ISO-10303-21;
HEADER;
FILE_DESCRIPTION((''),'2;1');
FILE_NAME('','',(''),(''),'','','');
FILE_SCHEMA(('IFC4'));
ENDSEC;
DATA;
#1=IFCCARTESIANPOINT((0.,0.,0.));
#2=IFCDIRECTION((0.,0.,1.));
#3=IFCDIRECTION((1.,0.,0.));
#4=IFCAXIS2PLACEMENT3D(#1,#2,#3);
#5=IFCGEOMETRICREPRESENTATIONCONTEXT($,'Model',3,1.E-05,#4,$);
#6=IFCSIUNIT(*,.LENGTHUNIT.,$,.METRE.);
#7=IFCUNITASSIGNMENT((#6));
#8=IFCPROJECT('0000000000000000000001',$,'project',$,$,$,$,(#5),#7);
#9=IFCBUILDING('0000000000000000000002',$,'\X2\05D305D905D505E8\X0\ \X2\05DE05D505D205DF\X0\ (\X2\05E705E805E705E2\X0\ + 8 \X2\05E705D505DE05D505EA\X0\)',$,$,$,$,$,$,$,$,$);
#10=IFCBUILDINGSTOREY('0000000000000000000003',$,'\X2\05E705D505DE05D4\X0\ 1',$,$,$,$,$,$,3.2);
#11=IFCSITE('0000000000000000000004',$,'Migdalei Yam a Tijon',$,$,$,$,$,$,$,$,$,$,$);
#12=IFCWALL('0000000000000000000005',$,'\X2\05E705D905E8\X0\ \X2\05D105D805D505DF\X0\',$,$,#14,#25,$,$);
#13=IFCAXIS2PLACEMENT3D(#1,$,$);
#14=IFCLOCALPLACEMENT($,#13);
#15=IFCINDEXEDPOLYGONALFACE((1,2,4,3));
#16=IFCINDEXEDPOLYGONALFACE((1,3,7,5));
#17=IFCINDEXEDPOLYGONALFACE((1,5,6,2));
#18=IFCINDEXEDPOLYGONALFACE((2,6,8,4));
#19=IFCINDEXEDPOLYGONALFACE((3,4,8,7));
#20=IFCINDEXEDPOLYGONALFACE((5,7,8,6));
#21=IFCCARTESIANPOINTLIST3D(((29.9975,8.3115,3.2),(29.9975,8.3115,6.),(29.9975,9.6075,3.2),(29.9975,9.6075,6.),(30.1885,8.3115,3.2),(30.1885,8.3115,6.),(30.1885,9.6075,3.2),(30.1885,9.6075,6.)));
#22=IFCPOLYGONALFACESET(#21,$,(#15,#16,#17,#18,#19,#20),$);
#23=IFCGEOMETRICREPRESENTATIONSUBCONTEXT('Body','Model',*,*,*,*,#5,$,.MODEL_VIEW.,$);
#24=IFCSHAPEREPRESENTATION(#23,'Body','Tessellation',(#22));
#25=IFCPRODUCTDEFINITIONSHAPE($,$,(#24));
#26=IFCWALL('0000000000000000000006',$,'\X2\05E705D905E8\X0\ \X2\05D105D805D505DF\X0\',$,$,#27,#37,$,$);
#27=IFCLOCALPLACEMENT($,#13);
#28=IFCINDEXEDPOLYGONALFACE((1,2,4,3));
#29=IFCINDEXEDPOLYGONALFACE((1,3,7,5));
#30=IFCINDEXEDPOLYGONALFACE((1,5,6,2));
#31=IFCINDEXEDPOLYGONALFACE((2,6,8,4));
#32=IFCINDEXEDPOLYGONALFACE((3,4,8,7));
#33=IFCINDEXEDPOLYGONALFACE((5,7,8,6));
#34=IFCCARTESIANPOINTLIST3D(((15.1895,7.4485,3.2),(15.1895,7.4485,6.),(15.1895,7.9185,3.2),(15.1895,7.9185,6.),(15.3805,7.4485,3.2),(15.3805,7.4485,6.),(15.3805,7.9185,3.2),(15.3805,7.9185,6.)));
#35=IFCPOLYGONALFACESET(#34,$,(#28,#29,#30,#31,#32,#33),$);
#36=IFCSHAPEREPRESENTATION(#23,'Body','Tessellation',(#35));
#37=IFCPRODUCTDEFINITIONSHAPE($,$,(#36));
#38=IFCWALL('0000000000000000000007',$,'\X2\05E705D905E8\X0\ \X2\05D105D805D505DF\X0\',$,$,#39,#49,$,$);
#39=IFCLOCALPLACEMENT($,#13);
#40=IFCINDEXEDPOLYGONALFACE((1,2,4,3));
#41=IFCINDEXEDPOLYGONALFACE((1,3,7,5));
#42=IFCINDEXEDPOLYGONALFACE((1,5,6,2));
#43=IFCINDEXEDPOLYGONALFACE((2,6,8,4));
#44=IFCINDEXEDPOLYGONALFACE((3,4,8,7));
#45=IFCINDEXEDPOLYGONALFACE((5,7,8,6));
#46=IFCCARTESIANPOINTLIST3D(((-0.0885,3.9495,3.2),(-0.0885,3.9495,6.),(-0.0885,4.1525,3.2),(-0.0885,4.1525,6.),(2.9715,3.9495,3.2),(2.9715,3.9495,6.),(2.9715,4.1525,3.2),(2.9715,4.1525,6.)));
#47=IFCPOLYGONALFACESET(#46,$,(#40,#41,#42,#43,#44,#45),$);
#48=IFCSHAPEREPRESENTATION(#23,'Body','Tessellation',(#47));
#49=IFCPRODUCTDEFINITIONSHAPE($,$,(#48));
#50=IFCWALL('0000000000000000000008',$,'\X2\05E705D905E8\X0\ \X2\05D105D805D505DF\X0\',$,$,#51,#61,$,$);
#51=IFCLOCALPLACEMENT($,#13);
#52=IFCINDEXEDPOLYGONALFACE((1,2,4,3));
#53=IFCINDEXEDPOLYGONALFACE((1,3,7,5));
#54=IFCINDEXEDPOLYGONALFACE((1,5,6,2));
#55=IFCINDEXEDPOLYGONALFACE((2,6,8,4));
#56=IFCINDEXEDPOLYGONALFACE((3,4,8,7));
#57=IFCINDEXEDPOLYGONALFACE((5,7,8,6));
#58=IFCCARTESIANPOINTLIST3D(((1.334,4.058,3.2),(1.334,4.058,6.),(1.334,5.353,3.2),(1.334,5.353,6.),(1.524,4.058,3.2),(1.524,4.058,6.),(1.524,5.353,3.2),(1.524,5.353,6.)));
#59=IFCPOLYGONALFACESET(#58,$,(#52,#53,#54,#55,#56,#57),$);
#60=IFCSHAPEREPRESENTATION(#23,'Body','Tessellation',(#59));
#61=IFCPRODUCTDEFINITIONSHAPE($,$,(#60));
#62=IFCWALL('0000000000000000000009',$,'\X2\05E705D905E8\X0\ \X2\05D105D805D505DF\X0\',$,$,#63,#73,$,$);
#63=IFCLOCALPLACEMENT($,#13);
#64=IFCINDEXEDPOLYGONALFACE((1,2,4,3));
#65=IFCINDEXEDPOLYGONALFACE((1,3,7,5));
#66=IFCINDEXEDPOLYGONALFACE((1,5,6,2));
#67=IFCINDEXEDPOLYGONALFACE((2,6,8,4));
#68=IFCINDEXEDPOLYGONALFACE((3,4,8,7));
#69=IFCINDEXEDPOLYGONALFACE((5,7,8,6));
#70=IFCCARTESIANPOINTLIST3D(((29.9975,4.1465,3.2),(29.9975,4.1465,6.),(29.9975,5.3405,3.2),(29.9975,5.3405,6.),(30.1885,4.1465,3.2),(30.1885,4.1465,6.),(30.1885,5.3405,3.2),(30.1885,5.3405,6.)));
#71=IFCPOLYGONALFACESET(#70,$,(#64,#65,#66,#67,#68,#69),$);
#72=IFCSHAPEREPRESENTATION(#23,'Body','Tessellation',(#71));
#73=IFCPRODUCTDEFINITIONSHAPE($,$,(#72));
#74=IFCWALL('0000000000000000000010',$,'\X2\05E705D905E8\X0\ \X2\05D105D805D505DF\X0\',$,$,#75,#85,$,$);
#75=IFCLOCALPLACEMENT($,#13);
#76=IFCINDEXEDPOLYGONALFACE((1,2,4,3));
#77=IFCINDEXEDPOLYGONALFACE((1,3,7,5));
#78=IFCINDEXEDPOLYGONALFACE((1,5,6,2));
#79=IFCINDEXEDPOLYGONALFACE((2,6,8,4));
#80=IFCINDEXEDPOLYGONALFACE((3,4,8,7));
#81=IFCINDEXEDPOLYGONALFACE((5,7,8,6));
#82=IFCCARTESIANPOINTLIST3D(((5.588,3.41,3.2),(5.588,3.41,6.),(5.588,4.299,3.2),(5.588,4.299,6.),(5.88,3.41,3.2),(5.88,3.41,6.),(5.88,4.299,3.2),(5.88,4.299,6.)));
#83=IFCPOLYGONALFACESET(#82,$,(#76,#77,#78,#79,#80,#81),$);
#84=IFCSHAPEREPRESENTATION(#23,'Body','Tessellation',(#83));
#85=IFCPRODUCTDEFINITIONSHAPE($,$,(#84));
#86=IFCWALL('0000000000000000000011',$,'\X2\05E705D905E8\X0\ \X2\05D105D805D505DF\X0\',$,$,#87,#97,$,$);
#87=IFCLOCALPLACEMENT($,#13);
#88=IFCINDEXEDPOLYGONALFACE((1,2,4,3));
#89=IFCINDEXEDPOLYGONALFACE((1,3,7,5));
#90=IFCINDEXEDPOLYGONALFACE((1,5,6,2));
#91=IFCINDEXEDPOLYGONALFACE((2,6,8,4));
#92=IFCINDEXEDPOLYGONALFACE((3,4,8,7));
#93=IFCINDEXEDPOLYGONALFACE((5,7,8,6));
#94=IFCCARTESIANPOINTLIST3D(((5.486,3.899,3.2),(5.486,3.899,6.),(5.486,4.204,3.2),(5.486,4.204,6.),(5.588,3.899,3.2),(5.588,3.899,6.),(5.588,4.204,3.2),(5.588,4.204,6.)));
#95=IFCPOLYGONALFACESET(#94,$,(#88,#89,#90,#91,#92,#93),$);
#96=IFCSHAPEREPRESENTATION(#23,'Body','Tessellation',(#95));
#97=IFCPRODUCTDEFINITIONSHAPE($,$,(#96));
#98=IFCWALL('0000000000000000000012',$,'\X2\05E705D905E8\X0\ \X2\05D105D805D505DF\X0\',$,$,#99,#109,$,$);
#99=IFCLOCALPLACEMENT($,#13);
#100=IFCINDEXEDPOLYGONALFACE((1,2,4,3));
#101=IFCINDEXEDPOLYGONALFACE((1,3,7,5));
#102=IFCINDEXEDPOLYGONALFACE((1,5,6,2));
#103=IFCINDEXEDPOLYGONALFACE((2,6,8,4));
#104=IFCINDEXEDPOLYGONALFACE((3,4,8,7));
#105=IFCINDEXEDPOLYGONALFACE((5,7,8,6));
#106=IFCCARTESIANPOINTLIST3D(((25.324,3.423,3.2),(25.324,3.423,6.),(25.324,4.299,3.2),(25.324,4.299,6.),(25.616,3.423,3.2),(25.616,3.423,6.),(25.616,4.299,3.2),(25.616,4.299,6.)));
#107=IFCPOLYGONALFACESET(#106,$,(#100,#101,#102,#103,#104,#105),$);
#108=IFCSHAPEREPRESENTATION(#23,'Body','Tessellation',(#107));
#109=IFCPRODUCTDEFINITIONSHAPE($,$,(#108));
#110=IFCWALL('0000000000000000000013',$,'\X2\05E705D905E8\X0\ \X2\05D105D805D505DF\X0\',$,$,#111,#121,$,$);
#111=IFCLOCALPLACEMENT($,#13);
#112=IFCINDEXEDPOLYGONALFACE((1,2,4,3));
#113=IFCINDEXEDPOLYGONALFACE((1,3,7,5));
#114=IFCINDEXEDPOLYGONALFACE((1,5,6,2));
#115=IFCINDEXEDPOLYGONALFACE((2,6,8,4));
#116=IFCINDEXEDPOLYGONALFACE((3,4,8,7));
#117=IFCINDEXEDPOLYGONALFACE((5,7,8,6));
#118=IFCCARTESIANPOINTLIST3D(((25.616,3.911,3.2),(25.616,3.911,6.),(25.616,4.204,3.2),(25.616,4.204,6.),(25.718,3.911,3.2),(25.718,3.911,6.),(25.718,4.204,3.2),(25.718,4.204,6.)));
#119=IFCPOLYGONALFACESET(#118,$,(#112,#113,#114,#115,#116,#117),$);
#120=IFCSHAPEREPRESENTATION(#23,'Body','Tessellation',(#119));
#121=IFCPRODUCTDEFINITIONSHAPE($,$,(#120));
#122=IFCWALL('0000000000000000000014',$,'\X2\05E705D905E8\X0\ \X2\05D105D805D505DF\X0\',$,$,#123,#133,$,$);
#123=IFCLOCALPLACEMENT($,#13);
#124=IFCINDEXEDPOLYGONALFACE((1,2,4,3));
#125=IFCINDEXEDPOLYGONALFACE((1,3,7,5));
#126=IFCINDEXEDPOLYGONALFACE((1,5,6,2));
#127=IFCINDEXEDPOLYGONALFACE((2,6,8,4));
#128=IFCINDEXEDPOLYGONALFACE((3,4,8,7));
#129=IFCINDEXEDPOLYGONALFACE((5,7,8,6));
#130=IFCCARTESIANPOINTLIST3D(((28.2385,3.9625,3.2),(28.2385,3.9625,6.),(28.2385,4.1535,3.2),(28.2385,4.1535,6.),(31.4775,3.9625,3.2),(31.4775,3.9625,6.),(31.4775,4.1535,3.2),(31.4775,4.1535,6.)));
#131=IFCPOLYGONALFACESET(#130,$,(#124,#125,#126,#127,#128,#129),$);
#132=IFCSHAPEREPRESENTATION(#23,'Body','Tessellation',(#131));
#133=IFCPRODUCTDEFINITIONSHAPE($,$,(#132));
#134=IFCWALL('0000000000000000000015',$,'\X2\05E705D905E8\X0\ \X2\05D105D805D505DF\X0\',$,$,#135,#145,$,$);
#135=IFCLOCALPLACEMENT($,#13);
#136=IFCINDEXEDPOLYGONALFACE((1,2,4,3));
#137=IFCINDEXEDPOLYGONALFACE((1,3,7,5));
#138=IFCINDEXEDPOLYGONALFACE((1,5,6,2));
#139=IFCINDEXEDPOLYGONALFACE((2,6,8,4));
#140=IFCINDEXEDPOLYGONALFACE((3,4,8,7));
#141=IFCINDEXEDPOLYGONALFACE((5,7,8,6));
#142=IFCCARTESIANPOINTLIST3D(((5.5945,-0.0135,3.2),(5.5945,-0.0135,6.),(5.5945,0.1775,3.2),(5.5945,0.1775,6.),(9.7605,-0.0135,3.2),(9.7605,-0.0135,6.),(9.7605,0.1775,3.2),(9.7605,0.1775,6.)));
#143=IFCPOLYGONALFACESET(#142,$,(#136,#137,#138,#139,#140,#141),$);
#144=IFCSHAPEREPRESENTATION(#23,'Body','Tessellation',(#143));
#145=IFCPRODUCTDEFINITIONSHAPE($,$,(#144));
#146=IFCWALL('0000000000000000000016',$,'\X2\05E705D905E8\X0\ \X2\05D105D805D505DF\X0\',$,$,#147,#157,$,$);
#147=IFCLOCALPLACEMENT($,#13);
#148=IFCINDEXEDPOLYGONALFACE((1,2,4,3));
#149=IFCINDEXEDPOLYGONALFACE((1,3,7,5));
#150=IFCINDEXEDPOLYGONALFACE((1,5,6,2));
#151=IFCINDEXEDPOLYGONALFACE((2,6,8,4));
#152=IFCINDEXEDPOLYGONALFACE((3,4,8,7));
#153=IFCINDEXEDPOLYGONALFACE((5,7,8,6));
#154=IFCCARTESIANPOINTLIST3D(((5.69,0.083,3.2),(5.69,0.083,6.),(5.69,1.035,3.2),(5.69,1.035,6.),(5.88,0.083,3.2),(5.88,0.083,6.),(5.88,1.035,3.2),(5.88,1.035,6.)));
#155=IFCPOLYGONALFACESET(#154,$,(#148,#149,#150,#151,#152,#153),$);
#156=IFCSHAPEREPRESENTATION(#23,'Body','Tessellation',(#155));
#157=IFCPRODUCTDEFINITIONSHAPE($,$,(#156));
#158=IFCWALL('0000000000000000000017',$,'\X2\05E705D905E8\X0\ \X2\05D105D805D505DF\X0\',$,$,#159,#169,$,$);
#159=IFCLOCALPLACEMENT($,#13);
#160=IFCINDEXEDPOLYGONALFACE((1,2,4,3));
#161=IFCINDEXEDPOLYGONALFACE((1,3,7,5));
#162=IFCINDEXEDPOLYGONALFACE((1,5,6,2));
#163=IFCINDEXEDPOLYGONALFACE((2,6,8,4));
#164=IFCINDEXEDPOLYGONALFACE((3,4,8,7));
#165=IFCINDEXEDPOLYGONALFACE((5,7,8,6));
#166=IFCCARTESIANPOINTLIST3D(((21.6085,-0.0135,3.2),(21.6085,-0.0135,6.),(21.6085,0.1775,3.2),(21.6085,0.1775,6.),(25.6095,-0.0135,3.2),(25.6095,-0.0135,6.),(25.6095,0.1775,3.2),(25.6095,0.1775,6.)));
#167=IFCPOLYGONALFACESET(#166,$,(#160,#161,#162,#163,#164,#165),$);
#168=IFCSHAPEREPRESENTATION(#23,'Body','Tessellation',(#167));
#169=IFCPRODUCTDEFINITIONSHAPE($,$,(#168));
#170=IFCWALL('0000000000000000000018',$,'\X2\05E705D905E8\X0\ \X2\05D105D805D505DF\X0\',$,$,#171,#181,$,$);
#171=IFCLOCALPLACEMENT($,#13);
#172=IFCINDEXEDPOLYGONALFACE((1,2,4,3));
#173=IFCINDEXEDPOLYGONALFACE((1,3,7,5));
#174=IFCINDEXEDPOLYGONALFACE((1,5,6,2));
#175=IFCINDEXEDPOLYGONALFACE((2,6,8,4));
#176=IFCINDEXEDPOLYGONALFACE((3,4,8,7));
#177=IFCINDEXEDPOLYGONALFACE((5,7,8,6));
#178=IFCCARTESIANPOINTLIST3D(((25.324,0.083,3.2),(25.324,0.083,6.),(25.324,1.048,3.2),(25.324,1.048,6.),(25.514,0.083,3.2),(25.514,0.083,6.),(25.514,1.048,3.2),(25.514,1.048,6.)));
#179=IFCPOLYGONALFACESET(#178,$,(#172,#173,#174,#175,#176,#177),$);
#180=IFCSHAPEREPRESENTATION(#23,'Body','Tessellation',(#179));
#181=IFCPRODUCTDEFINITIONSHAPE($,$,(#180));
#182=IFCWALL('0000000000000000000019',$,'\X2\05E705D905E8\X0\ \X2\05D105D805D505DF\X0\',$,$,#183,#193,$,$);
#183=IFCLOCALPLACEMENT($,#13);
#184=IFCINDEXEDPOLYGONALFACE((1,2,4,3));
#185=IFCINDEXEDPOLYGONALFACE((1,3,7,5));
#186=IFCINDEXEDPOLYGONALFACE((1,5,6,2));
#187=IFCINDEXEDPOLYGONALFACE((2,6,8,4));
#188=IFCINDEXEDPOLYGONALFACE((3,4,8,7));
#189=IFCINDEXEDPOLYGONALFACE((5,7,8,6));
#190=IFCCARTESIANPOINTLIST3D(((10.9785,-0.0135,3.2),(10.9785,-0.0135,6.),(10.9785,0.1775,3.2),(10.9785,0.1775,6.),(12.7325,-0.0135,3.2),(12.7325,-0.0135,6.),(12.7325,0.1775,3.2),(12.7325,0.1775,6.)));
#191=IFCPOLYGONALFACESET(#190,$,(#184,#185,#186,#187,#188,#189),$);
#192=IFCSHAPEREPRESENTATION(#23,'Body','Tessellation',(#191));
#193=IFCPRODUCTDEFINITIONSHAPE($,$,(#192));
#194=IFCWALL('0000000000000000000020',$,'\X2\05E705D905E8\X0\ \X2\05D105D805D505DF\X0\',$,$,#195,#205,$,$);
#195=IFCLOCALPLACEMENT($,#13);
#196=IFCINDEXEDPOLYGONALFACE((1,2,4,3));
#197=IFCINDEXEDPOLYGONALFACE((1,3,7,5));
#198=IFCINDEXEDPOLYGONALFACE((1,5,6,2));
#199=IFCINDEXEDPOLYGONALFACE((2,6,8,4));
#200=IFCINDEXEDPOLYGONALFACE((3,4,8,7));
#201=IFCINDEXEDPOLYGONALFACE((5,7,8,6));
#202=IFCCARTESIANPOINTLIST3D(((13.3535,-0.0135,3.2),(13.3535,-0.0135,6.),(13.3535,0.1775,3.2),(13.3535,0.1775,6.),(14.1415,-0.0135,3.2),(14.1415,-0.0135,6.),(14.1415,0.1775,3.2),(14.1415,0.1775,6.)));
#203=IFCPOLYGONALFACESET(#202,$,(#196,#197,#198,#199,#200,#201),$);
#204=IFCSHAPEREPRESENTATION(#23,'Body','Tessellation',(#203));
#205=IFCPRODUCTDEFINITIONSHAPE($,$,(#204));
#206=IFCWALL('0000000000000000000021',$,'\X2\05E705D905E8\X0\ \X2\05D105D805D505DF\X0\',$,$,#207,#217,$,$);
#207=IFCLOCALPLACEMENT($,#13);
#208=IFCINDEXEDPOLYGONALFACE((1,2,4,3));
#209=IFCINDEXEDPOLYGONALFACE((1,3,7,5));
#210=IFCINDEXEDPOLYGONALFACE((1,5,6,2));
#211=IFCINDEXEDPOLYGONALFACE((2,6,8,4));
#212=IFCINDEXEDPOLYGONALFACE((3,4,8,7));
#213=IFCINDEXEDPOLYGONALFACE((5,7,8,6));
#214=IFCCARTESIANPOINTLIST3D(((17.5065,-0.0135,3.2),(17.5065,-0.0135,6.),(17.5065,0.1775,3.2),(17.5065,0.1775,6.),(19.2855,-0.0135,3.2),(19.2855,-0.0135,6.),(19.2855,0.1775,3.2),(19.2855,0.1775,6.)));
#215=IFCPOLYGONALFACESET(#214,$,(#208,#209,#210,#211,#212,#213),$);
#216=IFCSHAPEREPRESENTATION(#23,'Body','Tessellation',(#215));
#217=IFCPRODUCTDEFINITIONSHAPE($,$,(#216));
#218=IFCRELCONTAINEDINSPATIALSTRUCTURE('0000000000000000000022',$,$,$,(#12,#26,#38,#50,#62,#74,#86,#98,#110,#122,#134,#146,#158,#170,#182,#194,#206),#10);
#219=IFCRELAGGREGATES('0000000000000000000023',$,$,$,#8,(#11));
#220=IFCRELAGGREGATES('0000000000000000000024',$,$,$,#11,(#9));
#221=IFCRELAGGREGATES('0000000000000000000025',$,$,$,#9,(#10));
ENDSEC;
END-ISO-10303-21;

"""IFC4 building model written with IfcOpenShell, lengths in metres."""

from ifc_helpers import new_model, si_unit, frame, origin_with_axes, context, subcontext, project, spatial, line, indexed_curve, outline, extrude, element, save


model = new_model("IFC4")

# Units and contexts
model_context = context("Model", 3, precision=1e-05, world=origin_with_axes())
body_context = subcontext(model_context, "Body", "Model", "MODEL_VIEW")
ifc_project = project(units=[si_unit("LENGTHUNIT", "METRE")], contexts=[model_context])

# Site, building, storey
site = spatial("IfcSite", under=ifc_project, Name="Migdalei Yam a Tijon")
building = spatial("IfcBuilding", under=site, Name="דיור מוגן (קרקע + 8 קומות)")
storey = spatial("IfcBuildingStorey", under=building, Name="קומה 1", Elevation=3.2)

# Walls
element("IfcWall", 1, inside=storey, Name="קיר בטון", context=body_context, shape_type="SweptSolid", body=[
    extrude(outline(indexed_curve([(0.0, 0.0), (0.191, 0.0), (0.191, 1.296), (0.0, 1.296)], segments=[line(1, 2, 3, 4, 1)])), frame((29.9975, 8.3115, 3.2), z_axis=(0.0, 0.0, 1.0), x_axis=(1.0, 0.0, 0.0)), (0.0, 0.0, 1.0), 2.8),
])
element("IfcWall", 2, inside=storey, Name="קיר בטון", context=body_context, shape_type="SweptSolid", body=[
    extrude(outline(indexed_curve([(0.0, 0.0), (0.191, 0.0), (0.191, 0.47), (0.0, 0.47)], segments=[line(1, 2, 3, 4, 1)])), frame((15.1895, 7.4485, 3.2), z_axis=(0.0, 0.0, 1.0), x_axis=(1.0, 0.0, 0.0)), (0.0, 0.0, 1.0), 2.8),
])
element("IfcWall", 3, inside=storey, Name="קיר בטון", context=body_context, shape_type="SweptSolid", body=[
    extrude(outline(indexed_curve([(0.0, 0.0), (3.06, 0.0), (3.06, 0.203), (0.0, 0.203)], segments=[line(1, 2, 3, 4, 1)])), frame((-0.0885, 3.9495, 3.2), z_axis=(0.0, 0.0, 1.0), x_axis=(1.0, 0.0, 0.0)), (0.0, 0.0, 1.0), 2.8),
])
element("IfcWall", 4, inside=storey, Name="קיר בטון", context=body_context, shape_type="SweptSolid", body=[
    extrude(outline(indexed_curve([(0.0, 0.0), (0.19, 0.0), (0.19, 1.295), (0.0, 1.295)], segments=[line(1, 2, 3, 4, 1)])), frame((1.334, 4.058, 3.2), z_axis=(0.0, 0.0, 1.0), x_axis=(1.0, 0.0, 0.0)), (0.0, 0.0, 1.0), 2.8),
])
element("IfcWall", 5, inside=storey, Name="קיר בטון", context=body_context, shape_type="SweptSolid", body=[
    extrude(outline(indexed_curve([(0.0, 0.0), (0.191, 0.0), (0.191, 1.194), (0.0, 1.194)], segments=[line(1, 2, 3, 4, 1)])), frame((29.9975, 4.1465, 3.2), z_axis=(0.0, 0.0, 1.0), x_axis=(1.0, 0.0, 0.0)), (0.0, 0.0, 1.0), 2.8),
])
element("IfcWall", 6, inside=storey, Name="קיר בטון", context=body_context, shape_type="SweptSolid", body=[
    extrude(outline(indexed_curve([(0.0, 0.0), (0.292, 0.0), (0.292, 0.889), (0.0, 0.889)], segments=[line(1, 2, 3, 4, 1)])), frame((5.588, 3.41, 3.2), z_axis=(0.0, 0.0, 1.0), x_axis=(1.0, 0.0, 0.0)), (0.0, 0.0, 1.0), 2.8),
])
element("IfcWall", 7, inside=storey, Name="קיר בטון", context=body_context, shape_type="SweptSolid", body=[
    extrude(outline(indexed_curve([(0.0, 0.0), (0.102, 0.0), (0.102, 0.305), (0.0, 0.305)], segments=[line(1, 2, 3, 4, 1)])), frame((5.486, 3.899, 3.2), z_axis=(0.0, 0.0, 1.0), x_axis=(1.0, 0.0, 0.0)), (0.0, 0.0, 1.0), 2.8),
])
element("IfcWall", 8, inside=storey, Name="קיר בטון", context=body_context, shape_type="SweptSolid", body=[
    extrude(outline(indexed_curve([(0.0, 0.0), (0.292, 0.0), (0.292, 0.876), (0.0, 0.876)], segments=[line(1, 2, 3, 4, 1)])), frame((25.324, 3.423, 3.2), z_axis=(0.0, 0.0, 1.0), x_axis=(1.0, 0.0, 0.0)), (0.0, 0.0, 1.0), 2.8),
])
element("IfcWall", 9, inside=storey, Name="קיר בטון", context=body_context, shape_type="SweptSolid", body=[
    extrude(outline(indexed_curve([(0.0, 0.0), (0.102, 0.0), (0.102, 0.293), (0.0, 0.293)], segments=[line(1, 2, 3, 4, 1)])), frame((25.616, 3.911, 3.2), z_axis=(0.0, 0.0, 1.0), x_axis=(1.0, 0.0, 0.0)), (0.0, 0.0, 1.0), 2.8),
])
element("IfcWall", 10, inside=storey, Name="קיר בטון", context=body_context, shape_type="SweptSolid", body=[
    extrude(outline(indexed_curve([(0.0, 0.0), (3.239, 0.0), (3.239, 0.191), (0.0, 0.191)], segments=[line(1, 2, 3, 4, 1)])), frame((28.2385, 3.9625, 3.2), z_axis=(0.0, 0.0, 1.0), x_axis=(1.0, 0.0, 0.0)), (0.0, 0.0, 1.0), 2.8),
])
element("IfcWall", 11, inside=storey, Name="קיר בטון", context=body_context, shape_type="SweptSolid", body=[
    extrude(outline(indexed_curve([(0.0, 0.0), (4.166, 0.0), (4.166, 0.191), (0.0, 0.191)], segments=[line(1, 2, 3, 4, 1)])), frame((5.5945, -0.0135, 3.2), z_axis=(0.0, 0.0, 1.0), x_axis=(1.0, 0.0, 0.0)), (0.0, 0.0, 1.0), 2.8),
])
element("IfcWall", 12, inside=storey, Name="קיר בטון", context=body_context, shape_type="SweptSolid", body=[
    extrude(outline(indexed_curve([(0.0, 0.0), (0.19, 0.0), (0.19, 0.952), (0.0, 0.952)], segments=[line(1, 2, 3, 4, 1)])), frame((5.69, 0.083, 3.2), z_axis=(0.0, 0.0, 1.0), x_axis=(1.0, 0.0, 0.0)), (0.0, 0.0, 1.0), 2.8),
])
element("IfcWall", 13, inside=storey, Name="קיר בטון", context=body_context, shape_type="SweptSolid", body=[
    extrude(outline(indexed_curve([(0.0, 0.0), (4.001, 0.0), (4.001, 0.191), (0.0, 0.191)], segments=[line(1, 2, 3, 4, 1)])), frame((21.6085, -0.0135, 3.2), z_axis=(0.0, 0.0, 1.0), x_axis=(1.0, 0.0, 0.0)), (0.0, 0.0, 1.0), 2.8),
])
element("IfcWall", 14, inside=storey, Name="קיר בטון", context=body_context, shape_type="SweptSolid", body=[
    extrude(outline(indexed_curve([(0.0, 0.0), (0.19, 0.0), (0.19, 0.965), (0.0, 0.965)], segments=[line(1, 2, 3, 4, 1)])), frame((25.324, 0.083, 3.2), z_axis=(0.0, 0.0, 1.0), x_axis=(1.0, 0.0, 0.0)), (0.0, 0.0, 1.0), 2.8),
])
element("IfcWall", 15, inside=storey, Name="קיר בטון", context=body_context, shape_type="SweptSolid", body=[
    extrude(outline(indexed_curve([(0.0, 0.0), (1.754, 0.0), (1.754, 0.191), (0.0, 0.191)], segments=[line(1, 2, 3, 4, 1)])), frame((10.9785, -0.0135, 3.2), z_axis=(0.0, 0.0, 1.0), x_axis=(1.0, 0.0, 0.0)), (0.0, 0.0, 1.0), 2.8),
])
element("IfcWall", 16, inside=storey, Name="קיר בטון", context=body_context, shape_type="SweptSolid", body=[
    extrude(outline(indexed_curve([(0.0, 0.0), (0.788, 0.0), (0.788, 0.191), (0.0, 0.191)], segments=[line(1, 2, 3, 4, 1)])), frame((13.3535, -0.0135, 3.2), z_axis=(0.0, 0.0, 1.0), x_axis=(1.0, 0.0, 0.0)), (0.0, 0.0, 1.0), 2.8),
])
element("IfcWall", 17, inside=storey, Name="קיר בטון", context=body_context, shape_type="SweptSolid", body=[
    extrude(outline(indexed_curve([(0.0, 0.0), (1.779, 0.0), (1.779, 0.191), (0.0, 0.191)], segments=[line(1, 2, 3, 4, 1)])), frame((17.5065, -0.0135, 3.2), z_axis=(0.0, 0.0, 1.0), x_axis=(1.0, 0.0, 0.0)), (0.0, 0.0, 1.0), 2.8),
])

save(model, "model.ifc")
